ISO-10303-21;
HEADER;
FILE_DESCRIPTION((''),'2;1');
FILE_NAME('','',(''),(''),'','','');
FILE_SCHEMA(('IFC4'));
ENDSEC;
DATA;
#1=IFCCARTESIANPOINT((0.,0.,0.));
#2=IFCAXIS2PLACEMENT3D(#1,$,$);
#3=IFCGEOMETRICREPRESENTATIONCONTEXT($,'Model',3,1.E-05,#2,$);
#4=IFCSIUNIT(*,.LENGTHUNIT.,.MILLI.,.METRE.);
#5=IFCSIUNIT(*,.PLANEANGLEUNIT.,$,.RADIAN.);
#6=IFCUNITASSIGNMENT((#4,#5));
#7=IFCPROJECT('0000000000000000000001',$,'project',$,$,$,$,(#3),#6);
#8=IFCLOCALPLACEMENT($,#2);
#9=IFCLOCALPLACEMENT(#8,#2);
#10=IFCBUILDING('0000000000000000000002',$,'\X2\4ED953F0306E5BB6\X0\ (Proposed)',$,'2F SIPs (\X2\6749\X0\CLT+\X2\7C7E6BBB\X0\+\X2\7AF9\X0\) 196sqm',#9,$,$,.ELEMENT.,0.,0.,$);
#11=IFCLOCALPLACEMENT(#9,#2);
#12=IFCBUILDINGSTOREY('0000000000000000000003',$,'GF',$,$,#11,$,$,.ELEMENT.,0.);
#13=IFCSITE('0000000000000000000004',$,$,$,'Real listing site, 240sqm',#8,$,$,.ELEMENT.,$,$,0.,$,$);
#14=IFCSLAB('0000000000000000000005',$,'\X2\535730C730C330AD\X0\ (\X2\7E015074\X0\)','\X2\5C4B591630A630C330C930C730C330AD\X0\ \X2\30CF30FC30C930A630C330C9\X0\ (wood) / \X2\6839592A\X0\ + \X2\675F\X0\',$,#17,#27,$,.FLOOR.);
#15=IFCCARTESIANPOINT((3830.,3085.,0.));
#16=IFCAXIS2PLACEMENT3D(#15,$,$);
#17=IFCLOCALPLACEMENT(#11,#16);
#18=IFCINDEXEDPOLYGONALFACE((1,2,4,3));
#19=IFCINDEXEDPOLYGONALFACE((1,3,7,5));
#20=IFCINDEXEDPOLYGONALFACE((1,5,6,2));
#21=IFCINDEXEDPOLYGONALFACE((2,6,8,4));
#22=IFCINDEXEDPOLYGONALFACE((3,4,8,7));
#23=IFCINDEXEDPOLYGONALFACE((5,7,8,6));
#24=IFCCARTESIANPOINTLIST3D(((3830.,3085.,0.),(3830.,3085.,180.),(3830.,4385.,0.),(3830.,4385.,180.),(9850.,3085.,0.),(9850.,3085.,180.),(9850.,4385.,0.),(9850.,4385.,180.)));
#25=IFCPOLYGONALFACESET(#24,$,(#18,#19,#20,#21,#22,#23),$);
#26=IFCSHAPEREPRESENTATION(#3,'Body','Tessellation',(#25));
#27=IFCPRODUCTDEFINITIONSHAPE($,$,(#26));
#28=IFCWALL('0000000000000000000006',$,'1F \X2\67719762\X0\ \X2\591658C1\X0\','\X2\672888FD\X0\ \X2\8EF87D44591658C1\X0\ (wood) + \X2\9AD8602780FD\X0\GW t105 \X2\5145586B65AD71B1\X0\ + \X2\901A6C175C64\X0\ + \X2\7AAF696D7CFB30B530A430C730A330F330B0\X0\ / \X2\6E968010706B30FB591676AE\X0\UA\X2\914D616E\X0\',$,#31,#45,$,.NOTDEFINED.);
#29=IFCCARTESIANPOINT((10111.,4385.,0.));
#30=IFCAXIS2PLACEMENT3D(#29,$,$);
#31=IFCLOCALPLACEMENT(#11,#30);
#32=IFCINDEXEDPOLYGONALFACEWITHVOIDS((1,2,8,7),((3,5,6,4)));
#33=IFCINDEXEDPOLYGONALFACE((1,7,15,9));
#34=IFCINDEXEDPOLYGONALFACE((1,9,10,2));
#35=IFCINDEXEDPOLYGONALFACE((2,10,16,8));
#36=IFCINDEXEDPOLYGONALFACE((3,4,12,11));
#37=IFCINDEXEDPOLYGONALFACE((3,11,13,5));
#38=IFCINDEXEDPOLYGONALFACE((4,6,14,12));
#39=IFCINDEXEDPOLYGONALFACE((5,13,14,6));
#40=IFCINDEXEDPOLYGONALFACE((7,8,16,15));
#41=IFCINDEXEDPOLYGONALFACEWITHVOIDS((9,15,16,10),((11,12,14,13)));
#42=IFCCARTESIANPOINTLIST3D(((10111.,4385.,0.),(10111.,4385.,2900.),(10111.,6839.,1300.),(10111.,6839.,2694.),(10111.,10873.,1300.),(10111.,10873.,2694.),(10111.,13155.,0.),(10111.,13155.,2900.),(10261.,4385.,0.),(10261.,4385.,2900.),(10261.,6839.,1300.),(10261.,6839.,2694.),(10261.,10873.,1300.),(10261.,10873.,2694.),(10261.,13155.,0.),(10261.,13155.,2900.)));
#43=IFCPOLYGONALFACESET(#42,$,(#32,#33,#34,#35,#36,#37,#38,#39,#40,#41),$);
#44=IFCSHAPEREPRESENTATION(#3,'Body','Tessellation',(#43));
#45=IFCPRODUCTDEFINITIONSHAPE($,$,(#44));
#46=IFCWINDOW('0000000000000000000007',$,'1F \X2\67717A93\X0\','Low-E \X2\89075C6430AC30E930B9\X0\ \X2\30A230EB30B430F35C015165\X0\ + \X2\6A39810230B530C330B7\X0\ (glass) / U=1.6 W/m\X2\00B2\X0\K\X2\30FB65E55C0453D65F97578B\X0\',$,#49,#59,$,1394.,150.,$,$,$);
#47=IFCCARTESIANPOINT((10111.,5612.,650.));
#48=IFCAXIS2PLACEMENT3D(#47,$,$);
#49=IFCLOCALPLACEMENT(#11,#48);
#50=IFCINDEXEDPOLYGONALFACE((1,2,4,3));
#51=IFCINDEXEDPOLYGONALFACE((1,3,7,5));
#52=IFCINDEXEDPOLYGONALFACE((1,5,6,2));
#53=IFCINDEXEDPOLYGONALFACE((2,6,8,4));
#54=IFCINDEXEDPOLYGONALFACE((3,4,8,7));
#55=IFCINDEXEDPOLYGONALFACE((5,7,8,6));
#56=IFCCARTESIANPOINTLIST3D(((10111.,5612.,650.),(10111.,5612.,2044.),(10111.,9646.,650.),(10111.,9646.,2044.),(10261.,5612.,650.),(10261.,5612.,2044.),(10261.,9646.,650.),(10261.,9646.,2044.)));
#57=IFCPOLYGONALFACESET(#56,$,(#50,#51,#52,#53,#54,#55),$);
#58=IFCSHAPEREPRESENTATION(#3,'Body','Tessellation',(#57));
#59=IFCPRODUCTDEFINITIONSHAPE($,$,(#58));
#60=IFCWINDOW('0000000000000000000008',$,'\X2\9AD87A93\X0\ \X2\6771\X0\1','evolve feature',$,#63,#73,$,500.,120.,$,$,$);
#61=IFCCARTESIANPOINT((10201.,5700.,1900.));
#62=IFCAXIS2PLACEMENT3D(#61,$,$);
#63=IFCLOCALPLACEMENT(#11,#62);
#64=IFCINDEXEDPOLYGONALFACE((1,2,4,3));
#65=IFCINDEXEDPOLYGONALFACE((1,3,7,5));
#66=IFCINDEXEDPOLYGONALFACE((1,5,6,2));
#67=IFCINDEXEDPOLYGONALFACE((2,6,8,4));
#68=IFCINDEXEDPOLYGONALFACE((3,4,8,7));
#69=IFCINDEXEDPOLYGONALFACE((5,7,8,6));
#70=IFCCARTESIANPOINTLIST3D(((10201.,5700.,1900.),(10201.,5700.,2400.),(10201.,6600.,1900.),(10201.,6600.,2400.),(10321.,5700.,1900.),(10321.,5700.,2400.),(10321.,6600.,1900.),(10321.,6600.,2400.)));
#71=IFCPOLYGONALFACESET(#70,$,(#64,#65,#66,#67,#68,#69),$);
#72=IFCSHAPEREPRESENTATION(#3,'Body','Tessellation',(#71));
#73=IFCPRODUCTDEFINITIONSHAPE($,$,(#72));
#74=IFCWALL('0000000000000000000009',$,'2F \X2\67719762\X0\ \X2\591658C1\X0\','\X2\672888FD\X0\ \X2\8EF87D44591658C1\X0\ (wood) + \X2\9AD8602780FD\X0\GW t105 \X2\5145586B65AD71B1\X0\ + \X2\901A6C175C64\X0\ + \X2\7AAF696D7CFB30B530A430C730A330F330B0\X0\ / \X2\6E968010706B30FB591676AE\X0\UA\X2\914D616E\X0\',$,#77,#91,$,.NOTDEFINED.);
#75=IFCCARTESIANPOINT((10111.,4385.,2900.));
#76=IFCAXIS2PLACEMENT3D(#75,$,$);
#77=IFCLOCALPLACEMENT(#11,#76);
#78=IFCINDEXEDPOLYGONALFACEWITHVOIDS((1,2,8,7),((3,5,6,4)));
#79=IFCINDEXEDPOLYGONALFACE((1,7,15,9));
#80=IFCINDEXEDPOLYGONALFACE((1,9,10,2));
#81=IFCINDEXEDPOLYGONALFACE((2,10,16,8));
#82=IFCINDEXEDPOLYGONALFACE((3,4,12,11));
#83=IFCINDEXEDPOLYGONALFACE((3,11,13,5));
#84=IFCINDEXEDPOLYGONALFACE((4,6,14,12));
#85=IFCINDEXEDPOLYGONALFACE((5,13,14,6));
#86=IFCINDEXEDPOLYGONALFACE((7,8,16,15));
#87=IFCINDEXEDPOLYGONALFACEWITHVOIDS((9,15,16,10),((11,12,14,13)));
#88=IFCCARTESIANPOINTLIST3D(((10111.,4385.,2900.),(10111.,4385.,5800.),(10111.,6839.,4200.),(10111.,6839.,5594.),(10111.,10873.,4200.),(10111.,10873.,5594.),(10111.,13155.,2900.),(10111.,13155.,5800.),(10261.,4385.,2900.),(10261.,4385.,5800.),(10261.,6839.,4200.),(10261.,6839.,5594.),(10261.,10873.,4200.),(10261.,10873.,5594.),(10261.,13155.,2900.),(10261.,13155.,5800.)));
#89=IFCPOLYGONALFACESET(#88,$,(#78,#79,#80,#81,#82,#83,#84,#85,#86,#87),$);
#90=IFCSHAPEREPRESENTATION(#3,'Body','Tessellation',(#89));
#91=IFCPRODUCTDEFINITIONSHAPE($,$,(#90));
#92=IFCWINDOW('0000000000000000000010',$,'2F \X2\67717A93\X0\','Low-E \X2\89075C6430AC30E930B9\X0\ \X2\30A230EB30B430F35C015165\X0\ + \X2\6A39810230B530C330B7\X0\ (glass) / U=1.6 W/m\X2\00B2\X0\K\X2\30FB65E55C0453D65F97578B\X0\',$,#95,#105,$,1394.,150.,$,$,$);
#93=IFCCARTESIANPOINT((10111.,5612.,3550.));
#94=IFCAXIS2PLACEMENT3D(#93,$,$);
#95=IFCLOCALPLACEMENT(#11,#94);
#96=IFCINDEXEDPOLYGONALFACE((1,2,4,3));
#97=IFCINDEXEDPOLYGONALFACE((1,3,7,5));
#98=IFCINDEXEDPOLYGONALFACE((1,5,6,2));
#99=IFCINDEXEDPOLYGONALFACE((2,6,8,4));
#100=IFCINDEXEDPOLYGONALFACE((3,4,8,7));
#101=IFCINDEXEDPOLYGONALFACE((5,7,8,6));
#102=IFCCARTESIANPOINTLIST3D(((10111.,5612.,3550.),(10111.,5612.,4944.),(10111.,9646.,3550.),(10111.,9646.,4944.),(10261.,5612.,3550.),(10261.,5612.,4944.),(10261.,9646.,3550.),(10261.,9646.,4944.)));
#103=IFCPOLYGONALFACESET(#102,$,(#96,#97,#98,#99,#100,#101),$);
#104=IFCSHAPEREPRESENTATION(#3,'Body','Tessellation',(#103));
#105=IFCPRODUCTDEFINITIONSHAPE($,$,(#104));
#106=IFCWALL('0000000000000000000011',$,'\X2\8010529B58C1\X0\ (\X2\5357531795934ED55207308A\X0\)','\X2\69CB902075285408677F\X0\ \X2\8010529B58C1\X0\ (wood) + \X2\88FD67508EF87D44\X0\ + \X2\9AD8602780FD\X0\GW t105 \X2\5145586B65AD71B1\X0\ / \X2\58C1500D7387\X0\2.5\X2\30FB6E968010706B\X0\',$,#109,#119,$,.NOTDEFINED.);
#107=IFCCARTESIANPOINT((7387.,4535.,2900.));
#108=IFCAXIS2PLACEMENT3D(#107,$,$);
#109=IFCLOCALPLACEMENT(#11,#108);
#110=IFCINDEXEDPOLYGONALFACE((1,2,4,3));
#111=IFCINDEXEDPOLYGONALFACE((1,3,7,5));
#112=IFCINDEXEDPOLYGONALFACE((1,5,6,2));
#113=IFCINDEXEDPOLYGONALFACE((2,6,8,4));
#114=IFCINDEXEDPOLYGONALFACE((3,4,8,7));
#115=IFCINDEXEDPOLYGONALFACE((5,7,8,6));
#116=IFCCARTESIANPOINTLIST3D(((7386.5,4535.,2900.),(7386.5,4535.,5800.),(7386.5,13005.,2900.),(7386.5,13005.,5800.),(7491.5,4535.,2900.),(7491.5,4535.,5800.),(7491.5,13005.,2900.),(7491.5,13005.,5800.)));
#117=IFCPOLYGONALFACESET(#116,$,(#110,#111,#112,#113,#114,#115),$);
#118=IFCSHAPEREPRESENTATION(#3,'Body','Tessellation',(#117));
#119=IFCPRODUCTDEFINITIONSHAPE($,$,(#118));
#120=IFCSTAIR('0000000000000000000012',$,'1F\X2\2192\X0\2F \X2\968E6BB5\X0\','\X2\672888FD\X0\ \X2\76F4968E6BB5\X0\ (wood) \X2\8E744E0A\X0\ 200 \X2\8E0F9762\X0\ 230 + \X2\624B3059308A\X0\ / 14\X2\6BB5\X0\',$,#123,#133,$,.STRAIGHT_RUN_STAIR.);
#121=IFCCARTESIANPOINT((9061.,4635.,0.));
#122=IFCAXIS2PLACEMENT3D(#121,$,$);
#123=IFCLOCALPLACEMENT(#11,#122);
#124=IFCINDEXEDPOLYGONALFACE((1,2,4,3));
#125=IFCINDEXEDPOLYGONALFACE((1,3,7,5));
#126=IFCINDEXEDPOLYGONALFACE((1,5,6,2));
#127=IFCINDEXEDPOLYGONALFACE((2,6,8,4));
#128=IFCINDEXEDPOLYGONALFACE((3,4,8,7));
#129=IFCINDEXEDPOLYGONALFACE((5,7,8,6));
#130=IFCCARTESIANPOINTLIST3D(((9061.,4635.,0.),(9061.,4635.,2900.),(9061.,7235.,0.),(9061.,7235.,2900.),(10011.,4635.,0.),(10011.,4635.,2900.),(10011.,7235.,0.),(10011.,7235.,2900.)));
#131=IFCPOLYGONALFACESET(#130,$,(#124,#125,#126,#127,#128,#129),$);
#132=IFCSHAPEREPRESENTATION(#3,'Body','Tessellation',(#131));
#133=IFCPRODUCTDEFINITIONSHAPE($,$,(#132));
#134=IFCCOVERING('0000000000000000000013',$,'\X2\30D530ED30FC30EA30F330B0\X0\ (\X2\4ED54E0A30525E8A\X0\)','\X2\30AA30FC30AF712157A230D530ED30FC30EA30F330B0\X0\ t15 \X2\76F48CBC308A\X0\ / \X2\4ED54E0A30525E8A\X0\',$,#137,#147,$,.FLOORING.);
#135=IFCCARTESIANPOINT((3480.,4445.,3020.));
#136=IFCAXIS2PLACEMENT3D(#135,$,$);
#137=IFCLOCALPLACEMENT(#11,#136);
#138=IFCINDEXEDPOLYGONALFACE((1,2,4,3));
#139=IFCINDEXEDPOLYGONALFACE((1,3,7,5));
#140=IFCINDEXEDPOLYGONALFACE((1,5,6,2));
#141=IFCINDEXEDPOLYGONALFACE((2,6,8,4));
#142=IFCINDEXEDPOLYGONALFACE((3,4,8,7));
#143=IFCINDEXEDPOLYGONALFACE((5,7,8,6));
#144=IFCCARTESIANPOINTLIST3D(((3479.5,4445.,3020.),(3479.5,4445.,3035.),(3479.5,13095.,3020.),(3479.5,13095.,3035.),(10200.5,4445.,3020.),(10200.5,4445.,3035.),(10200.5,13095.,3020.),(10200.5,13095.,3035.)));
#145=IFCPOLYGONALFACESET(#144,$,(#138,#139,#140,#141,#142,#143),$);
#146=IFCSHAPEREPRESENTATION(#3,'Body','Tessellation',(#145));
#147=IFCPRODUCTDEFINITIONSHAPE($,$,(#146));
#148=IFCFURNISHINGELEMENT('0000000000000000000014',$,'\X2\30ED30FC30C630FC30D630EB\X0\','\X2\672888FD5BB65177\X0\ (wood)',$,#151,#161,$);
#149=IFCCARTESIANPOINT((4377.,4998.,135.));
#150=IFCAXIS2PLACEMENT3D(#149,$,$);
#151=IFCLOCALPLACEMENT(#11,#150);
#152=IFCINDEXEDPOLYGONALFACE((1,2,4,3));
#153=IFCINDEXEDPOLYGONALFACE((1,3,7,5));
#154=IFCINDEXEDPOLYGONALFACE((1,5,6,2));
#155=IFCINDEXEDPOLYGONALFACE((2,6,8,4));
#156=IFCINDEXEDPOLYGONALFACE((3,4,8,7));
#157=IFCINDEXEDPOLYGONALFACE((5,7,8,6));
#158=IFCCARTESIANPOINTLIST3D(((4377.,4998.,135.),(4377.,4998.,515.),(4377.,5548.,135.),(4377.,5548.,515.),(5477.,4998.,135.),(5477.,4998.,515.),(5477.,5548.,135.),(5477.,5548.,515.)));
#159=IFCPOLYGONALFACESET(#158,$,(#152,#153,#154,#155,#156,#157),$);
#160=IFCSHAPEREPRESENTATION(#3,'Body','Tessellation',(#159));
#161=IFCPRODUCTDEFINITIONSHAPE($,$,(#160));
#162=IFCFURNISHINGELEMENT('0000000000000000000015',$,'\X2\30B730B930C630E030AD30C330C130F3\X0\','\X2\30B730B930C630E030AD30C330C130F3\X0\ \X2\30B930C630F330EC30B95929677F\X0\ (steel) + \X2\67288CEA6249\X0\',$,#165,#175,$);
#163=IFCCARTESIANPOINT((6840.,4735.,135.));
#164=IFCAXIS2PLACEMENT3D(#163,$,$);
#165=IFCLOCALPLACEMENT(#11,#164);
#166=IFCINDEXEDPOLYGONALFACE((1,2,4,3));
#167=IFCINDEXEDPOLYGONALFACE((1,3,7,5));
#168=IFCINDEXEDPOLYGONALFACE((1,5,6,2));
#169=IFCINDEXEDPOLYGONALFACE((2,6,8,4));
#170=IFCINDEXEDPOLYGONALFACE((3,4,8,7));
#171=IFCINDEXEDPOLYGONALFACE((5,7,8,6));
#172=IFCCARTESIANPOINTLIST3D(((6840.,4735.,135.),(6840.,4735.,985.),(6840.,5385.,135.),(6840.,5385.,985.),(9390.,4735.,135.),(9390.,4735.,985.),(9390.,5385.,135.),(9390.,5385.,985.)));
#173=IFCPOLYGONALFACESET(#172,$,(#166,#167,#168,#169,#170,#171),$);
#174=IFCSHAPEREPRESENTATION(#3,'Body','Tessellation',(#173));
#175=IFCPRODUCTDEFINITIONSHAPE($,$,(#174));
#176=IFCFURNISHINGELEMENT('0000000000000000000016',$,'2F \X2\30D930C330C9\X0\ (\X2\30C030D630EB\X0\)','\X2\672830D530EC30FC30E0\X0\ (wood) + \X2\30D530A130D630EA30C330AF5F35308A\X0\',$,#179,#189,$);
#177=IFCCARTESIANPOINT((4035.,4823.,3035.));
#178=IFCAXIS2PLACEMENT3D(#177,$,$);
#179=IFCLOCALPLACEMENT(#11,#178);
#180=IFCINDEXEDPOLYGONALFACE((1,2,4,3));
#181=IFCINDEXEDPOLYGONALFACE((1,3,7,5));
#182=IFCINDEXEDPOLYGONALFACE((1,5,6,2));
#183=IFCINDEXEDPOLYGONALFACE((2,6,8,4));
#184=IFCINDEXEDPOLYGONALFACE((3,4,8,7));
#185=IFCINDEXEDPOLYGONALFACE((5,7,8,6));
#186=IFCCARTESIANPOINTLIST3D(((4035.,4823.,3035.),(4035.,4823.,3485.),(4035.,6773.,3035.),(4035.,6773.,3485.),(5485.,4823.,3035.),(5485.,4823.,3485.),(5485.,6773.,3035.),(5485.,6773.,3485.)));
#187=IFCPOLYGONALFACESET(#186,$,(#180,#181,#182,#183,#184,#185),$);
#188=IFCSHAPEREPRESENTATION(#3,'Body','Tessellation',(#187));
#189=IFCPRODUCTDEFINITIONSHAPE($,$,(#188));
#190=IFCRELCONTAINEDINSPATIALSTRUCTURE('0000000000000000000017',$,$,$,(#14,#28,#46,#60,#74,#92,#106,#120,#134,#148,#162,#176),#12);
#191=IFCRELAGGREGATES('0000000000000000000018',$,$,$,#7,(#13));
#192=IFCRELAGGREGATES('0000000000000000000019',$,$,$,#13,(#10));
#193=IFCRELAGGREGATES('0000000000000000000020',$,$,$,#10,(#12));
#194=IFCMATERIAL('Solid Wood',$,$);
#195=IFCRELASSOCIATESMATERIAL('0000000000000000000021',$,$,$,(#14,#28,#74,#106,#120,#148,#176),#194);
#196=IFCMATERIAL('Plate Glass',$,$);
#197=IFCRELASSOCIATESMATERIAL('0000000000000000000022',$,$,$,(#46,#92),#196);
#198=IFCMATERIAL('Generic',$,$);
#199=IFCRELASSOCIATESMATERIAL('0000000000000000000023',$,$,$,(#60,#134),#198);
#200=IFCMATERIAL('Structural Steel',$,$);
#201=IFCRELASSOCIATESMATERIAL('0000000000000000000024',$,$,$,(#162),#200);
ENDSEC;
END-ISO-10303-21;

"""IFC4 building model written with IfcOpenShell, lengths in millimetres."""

from ifc_helpers import new_model, si_unit, frame, frame_2d, origin, place, context, project, spatial, rectangle, extrude, material, element, fill, save


model = new_model("IFC4")

# Units and contexts
model_context = context("Model", 3, precision=1e-05, world=origin())
ifc_project = project(units=[si_unit("LENGTHUNIT", "METRE", prefix="MILLI"), si_unit("PLANEANGLEUNIT", "RADIAN")], contexts=[model_context])

# Site, building, storey
site_placement = place(None, origin())
site = spatial("IfcSite", under=ifc_project, at=site_placement, ObjectType="Real listing site, 240sqm", CompositionType="ELEMENT", RefElevation=0.0)
building_placement = place(site_placement, origin())
building = spatial("IfcBuilding", under=site, at=building_placement, Name="仙台の家 (Proposed)", ObjectType="2F SIPs (杉CLT+籾殻+竹) 196sqm", CompositionType="ELEMENT", ElevationOfRefHeight=0.0, ElevationOfTerrain=0.0)
storey_placement = place(building_placement, origin())
storey = spatial("IfcBuildingStorey", under=building, at=storey_placement, Name="GF", CompositionType="ELEMENT", Elevation=0.0)

# Slab
ifc_material_1 = material(Name="Solid Wood")
slab_placement = place(storey_placement, frame((3830.0, 3085.0, 0.0)))
element("IfcSlab", 1, at=slab_placement, inside=storey, material=ifc_material_1, Name="南デッキ (縁側)", Description="屋外ウッドデッキ ハードウッド (wood) / 根太 + 束", PredefinedType="FLOOR", context=model_context, shape_type="SweptSolid", body=[
    extrude(rectangle(XDim=6020.0, YDim=1300.0, at=frame_2d((3010.0, 650.0))), frame((3830.0, 3085.0, 0.0)), (0.0, 0.0, 1.0), 180.0),
])

# Wall, openings, windows
wall_1_placement = place(storey_placement, frame((10111.0, 4385.0, 0.0)))
wall_1 = element("IfcWall", 2, at=wall_1_placement, inside=storey, material=ifc_material_1, Name="1F 東面 外壁", Description="木製 軸組外壁 (wood) + 高性能GW t105 充填断熱 + 通気層 + 窯業系サイディング / 準耐火・外皮UA配慮", PredefinedType="NOTDEFINED", context=model_context, shape_type="SweptSolid", body=[
    extrude(rectangle(XDim=150.0, YDim=8770.0, at=frame_2d((75.0, 4385.0))), frame((10111.0, 4385.0, 0.0)), (0.0, 0.0, 1.0), 2900.0),
])
opening_1_placement = place(storey_placement, frame((10111.0, 5612.0, 650.0)))
opening_1 = element("IfcOpeningElement", 3, at=opening_1_placement, cuts=wall_1, PredefinedType="NOTDEFINED", context=model_context, shape_type="SweptSolid", body=[
    extrude(rectangle(XDim=150.0, YDim=4034.0, at=frame_2d((75.0, 2017.0))), frame((10111.0, 5612.0, 650.0)), (0.0, 0.0, 1.0), 1394.0),
])
opening_2_placement = place(storey_placement, frame((10201.0, 5700.0, 1900.0)))
opening_2 = element("IfcOpeningElement", 4, at=opening_2_placement, cuts=wall_1, PredefinedType="NOTDEFINED", context=model_context, shape_type="SweptSolid", body=[
    extrude(rectangle(XDim=120.0, YDim=900.0, at=frame_2d((60.0, 450.0))), frame((10201.0, 5700.0, 1900.0)), (0.0, 0.0, 1.0), 500.0),
])
ifc_material_2 = material(Name="Plate Glass")
window_1_placement = place(storey_placement, frame((10111.0, 5612.0, 650.0)))
window_1 = element("IfcWindow", 5, at=window_1_placement, inside=storey, material=ifc_material_2, Name="1F 東窓", Description="Low-E 複層ガラス アルゴン封入 + 樹脂サッシ (glass) / U=1.6 W/m²K・日射取得型", OverallHeight=1394.0, OverallWidth=150.0, context=model_context, shape_type="SweptSolid", body=[
    extrude(rectangle(XDim=150.0, YDim=4034.0, at=frame_2d((75.0, 2017.0))), frame((10111.0, 5612.0, 650.0)), (0.0, 0.0, 1.0), 1394.0),
])
fill(opening_1, window_1)
ifc_material_3 = material(Name="Generic")
window_2_placement = place(storey_placement, frame((10201.0, 5700.0, 1900.0)))
window_2 = element("IfcWindow", 6, at=window_2_placement, inside=storey, material=ifc_material_3, Name="高窓 東1", Description="evolve feature", OverallHeight=500.0, OverallWidth=120.0, context=model_context, shape_type="SweptSolid", body=[
    extrude(rectangle(XDim=120.0, YDim=900.0, at=frame_2d((60.0, 450.0))), frame((10201.0, 5700.0, 1900.0)), (0.0, 0.0, 1.0), 500.0),
])
fill(opening_2, window_2)

# Wall, opening, window
wall_2_placement = place(storey_placement, frame((10111.0, 4385.0, 2900.0)))
wall_2 = element("IfcWall", 7, at=wall_2_placement, inside=storey, material=ifc_material_1, Name="2F 東面 外壁", Description="木製 軸組外壁 (wood) + 高性能GW t105 充填断熱 + 通気層 + 窯業系サイディング / 準耐火・外皮UA配慮", PredefinedType="NOTDEFINED", context=model_context, shape_type="SweptSolid", body=[
    extrude(rectangle(XDim=150.0, YDim=8770.0, at=frame_2d((75.0, 4385.0))), frame((10111.0, 4385.0, 2900.0)), (0.0, 0.0, 1.0), 2900.0),
])
opening_3_placement = place(storey_placement, frame((10111.0, 5612.0, 3550.0)))
opening_3 = element("IfcOpeningElement", 8, at=opening_3_placement, cuts=wall_2, PredefinedType="NOTDEFINED", context=model_context, shape_type="SweptSolid", body=[
    extrude(rectangle(XDim=150.0, YDim=4034.0, at=frame_2d((75.0, 2017.0))), frame((10111.0, 5612.0, 3550.0)), (0.0, 0.0, 1.0), 1394.0),
])
window_3_placement = place(storey_placement, frame((10111.0, 5612.0, 3550.0)))
window_3 = element("IfcWindow", 9, at=window_3_placement, inside=storey, material=ifc_material_2, Name="2F 東窓", Description="Low-E 複層ガラス アルゴン封入 + 樹脂サッシ (glass) / U=1.6 W/m²K・日射取得型", OverallHeight=1394.0, OverallWidth=150.0, context=model_context, shape_type="SweptSolid", body=[
    extrude(rectangle(XDim=150.0, YDim=4034.0, at=frame_2d((75.0, 2017.0))), frame((10111.0, 5612.0, 3550.0)), (0.0, 0.0, 1.0), 1394.0),
])
fill(opening_3, window_3)

# Wall
wall_3_placement = place(storey_placement, frame((7387.0, 4535.0, 2900.0)))
element("IfcWall", 10, at=wall_3_placement, inside=storey, material=ifc_material_1, Name="耐力壁 (南北間仕切り)", Description="構造用合板 耐力壁 (wood) + 製材軸組 + 高性能GW t105 充填断熱 / 壁倍率2.5・準耐火", PredefinedType="NOTDEFINED", context=model_context, shape_type="SweptSolid", body=[
    extrude(rectangle(XDim=105.0, YDim=8470.0, at=frame_2d((52.0, 4235.0))), frame((7387.0, 4535.0, 2900.0)), (0.0, 0.0, 1.0), 2900.0),
])

# Stair
stair_placement = place(storey_placement, frame((9061.0, 4635.0, 0.0)))
element("IfcStair", 11, at=stair_placement, inside=storey, material=ifc_material_1, Name="1F→2F 階段", Description="木製 直階段 (wood) 蹴上 200 踏面 230 + 手すり / 14段", PredefinedType="STRAIGHT_RUN_STAIR", context=model_context, shape_type="SweptSolid", body=[
    extrude(rectangle(XDim=950.0, YDim=2600.0, at=frame_2d((475.0, 1300.0))), frame((9061.0, 4635.0, 0.0)), (0.0, 0.0, 1.0), 2900.0),
])

# Covering
covering_placement = place(storey_placement, frame((3480.0, 4445.0, 3020.0)))
element("IfcCovering", 12, at=covering_placement, inside=storey, material=ifc_material_3, Name="フローリング (仕上げ床)", Description="オーク無垢フローリング t15 直貼り / 仕上げ床", PredefinedType="FLOORING", context=model_context, shape_type="SweptSolid", body=[
    extrude(rectangle(XDim=6721.0, YDim=8650.0, at=frame_2d((3360.0, 4325.0))), frame((3480.0, 4445.0, 3020.0)), (0.0, 0.0, 1.0), 15.0),
])

# Furnishing elements
furnishing_1_placement = place(storey_placement, frame((4377.0, 4998.0, 135.0)))
element("IfcFurnishingElement", 13, at=furnishing_1_placement, inside=storey, material=ifc_material_1, Name="ローテーブル", Description="木製家具 (wood)", context=model_context, shape_type="SweptSolid", body=[
    extrude(rectangle(XDim=1100.0, YDim=550.0, at=frame_2d((550.0, 275.0))), frame((4377.0, 4998.0, 135.0)), (0.0, 0.0, 1.0), 380.0),
])
ifc_material_4 = material(Name="Structural Steel")
furnishing_2_placement = place(storey_placement, frame((6840.0, 4735.0, 135.0)))
element("IfcFurnishingElement", 14, at=furnishing_2_placement, inside=storey, material=ifc_material_4, Name="システムキッチン", Description="システムキッチン ステンレス天板 (steel) + 木質扉", context=model_context, shape_type="SweptSolid", body=[
    extrude(rectangle(XDim=2550.0, YDim=650.0, at=frame_2d((1275.0, 325.0))), frame((6840.0, 4735.0, 135.0)), (0.0, 0.0, 1.0), 850.0),
])
furnishing_3_placement = place(storey_placement, frame((4035.0, 4823.0, 3035.0)))
element("IfcFurnishingElement", 15, at=furnishing_3_placement, inside=storey, material=ifc_material_1, Name="2F ベッド (ダブル)", Description="木フレーム (wood) + ファブリック張り", context=model_context, shape_type="SweptSolid", body=[
    extrude(rectangle(XDim=1450.0, YDim=1950.0, at=frame_2d((725.0, 975.0))), frame((4035.0, 4823.0, 3035.0)), (0.0, 0.0, 1.0), 450.0),
])

save(model, "model.ifc")
